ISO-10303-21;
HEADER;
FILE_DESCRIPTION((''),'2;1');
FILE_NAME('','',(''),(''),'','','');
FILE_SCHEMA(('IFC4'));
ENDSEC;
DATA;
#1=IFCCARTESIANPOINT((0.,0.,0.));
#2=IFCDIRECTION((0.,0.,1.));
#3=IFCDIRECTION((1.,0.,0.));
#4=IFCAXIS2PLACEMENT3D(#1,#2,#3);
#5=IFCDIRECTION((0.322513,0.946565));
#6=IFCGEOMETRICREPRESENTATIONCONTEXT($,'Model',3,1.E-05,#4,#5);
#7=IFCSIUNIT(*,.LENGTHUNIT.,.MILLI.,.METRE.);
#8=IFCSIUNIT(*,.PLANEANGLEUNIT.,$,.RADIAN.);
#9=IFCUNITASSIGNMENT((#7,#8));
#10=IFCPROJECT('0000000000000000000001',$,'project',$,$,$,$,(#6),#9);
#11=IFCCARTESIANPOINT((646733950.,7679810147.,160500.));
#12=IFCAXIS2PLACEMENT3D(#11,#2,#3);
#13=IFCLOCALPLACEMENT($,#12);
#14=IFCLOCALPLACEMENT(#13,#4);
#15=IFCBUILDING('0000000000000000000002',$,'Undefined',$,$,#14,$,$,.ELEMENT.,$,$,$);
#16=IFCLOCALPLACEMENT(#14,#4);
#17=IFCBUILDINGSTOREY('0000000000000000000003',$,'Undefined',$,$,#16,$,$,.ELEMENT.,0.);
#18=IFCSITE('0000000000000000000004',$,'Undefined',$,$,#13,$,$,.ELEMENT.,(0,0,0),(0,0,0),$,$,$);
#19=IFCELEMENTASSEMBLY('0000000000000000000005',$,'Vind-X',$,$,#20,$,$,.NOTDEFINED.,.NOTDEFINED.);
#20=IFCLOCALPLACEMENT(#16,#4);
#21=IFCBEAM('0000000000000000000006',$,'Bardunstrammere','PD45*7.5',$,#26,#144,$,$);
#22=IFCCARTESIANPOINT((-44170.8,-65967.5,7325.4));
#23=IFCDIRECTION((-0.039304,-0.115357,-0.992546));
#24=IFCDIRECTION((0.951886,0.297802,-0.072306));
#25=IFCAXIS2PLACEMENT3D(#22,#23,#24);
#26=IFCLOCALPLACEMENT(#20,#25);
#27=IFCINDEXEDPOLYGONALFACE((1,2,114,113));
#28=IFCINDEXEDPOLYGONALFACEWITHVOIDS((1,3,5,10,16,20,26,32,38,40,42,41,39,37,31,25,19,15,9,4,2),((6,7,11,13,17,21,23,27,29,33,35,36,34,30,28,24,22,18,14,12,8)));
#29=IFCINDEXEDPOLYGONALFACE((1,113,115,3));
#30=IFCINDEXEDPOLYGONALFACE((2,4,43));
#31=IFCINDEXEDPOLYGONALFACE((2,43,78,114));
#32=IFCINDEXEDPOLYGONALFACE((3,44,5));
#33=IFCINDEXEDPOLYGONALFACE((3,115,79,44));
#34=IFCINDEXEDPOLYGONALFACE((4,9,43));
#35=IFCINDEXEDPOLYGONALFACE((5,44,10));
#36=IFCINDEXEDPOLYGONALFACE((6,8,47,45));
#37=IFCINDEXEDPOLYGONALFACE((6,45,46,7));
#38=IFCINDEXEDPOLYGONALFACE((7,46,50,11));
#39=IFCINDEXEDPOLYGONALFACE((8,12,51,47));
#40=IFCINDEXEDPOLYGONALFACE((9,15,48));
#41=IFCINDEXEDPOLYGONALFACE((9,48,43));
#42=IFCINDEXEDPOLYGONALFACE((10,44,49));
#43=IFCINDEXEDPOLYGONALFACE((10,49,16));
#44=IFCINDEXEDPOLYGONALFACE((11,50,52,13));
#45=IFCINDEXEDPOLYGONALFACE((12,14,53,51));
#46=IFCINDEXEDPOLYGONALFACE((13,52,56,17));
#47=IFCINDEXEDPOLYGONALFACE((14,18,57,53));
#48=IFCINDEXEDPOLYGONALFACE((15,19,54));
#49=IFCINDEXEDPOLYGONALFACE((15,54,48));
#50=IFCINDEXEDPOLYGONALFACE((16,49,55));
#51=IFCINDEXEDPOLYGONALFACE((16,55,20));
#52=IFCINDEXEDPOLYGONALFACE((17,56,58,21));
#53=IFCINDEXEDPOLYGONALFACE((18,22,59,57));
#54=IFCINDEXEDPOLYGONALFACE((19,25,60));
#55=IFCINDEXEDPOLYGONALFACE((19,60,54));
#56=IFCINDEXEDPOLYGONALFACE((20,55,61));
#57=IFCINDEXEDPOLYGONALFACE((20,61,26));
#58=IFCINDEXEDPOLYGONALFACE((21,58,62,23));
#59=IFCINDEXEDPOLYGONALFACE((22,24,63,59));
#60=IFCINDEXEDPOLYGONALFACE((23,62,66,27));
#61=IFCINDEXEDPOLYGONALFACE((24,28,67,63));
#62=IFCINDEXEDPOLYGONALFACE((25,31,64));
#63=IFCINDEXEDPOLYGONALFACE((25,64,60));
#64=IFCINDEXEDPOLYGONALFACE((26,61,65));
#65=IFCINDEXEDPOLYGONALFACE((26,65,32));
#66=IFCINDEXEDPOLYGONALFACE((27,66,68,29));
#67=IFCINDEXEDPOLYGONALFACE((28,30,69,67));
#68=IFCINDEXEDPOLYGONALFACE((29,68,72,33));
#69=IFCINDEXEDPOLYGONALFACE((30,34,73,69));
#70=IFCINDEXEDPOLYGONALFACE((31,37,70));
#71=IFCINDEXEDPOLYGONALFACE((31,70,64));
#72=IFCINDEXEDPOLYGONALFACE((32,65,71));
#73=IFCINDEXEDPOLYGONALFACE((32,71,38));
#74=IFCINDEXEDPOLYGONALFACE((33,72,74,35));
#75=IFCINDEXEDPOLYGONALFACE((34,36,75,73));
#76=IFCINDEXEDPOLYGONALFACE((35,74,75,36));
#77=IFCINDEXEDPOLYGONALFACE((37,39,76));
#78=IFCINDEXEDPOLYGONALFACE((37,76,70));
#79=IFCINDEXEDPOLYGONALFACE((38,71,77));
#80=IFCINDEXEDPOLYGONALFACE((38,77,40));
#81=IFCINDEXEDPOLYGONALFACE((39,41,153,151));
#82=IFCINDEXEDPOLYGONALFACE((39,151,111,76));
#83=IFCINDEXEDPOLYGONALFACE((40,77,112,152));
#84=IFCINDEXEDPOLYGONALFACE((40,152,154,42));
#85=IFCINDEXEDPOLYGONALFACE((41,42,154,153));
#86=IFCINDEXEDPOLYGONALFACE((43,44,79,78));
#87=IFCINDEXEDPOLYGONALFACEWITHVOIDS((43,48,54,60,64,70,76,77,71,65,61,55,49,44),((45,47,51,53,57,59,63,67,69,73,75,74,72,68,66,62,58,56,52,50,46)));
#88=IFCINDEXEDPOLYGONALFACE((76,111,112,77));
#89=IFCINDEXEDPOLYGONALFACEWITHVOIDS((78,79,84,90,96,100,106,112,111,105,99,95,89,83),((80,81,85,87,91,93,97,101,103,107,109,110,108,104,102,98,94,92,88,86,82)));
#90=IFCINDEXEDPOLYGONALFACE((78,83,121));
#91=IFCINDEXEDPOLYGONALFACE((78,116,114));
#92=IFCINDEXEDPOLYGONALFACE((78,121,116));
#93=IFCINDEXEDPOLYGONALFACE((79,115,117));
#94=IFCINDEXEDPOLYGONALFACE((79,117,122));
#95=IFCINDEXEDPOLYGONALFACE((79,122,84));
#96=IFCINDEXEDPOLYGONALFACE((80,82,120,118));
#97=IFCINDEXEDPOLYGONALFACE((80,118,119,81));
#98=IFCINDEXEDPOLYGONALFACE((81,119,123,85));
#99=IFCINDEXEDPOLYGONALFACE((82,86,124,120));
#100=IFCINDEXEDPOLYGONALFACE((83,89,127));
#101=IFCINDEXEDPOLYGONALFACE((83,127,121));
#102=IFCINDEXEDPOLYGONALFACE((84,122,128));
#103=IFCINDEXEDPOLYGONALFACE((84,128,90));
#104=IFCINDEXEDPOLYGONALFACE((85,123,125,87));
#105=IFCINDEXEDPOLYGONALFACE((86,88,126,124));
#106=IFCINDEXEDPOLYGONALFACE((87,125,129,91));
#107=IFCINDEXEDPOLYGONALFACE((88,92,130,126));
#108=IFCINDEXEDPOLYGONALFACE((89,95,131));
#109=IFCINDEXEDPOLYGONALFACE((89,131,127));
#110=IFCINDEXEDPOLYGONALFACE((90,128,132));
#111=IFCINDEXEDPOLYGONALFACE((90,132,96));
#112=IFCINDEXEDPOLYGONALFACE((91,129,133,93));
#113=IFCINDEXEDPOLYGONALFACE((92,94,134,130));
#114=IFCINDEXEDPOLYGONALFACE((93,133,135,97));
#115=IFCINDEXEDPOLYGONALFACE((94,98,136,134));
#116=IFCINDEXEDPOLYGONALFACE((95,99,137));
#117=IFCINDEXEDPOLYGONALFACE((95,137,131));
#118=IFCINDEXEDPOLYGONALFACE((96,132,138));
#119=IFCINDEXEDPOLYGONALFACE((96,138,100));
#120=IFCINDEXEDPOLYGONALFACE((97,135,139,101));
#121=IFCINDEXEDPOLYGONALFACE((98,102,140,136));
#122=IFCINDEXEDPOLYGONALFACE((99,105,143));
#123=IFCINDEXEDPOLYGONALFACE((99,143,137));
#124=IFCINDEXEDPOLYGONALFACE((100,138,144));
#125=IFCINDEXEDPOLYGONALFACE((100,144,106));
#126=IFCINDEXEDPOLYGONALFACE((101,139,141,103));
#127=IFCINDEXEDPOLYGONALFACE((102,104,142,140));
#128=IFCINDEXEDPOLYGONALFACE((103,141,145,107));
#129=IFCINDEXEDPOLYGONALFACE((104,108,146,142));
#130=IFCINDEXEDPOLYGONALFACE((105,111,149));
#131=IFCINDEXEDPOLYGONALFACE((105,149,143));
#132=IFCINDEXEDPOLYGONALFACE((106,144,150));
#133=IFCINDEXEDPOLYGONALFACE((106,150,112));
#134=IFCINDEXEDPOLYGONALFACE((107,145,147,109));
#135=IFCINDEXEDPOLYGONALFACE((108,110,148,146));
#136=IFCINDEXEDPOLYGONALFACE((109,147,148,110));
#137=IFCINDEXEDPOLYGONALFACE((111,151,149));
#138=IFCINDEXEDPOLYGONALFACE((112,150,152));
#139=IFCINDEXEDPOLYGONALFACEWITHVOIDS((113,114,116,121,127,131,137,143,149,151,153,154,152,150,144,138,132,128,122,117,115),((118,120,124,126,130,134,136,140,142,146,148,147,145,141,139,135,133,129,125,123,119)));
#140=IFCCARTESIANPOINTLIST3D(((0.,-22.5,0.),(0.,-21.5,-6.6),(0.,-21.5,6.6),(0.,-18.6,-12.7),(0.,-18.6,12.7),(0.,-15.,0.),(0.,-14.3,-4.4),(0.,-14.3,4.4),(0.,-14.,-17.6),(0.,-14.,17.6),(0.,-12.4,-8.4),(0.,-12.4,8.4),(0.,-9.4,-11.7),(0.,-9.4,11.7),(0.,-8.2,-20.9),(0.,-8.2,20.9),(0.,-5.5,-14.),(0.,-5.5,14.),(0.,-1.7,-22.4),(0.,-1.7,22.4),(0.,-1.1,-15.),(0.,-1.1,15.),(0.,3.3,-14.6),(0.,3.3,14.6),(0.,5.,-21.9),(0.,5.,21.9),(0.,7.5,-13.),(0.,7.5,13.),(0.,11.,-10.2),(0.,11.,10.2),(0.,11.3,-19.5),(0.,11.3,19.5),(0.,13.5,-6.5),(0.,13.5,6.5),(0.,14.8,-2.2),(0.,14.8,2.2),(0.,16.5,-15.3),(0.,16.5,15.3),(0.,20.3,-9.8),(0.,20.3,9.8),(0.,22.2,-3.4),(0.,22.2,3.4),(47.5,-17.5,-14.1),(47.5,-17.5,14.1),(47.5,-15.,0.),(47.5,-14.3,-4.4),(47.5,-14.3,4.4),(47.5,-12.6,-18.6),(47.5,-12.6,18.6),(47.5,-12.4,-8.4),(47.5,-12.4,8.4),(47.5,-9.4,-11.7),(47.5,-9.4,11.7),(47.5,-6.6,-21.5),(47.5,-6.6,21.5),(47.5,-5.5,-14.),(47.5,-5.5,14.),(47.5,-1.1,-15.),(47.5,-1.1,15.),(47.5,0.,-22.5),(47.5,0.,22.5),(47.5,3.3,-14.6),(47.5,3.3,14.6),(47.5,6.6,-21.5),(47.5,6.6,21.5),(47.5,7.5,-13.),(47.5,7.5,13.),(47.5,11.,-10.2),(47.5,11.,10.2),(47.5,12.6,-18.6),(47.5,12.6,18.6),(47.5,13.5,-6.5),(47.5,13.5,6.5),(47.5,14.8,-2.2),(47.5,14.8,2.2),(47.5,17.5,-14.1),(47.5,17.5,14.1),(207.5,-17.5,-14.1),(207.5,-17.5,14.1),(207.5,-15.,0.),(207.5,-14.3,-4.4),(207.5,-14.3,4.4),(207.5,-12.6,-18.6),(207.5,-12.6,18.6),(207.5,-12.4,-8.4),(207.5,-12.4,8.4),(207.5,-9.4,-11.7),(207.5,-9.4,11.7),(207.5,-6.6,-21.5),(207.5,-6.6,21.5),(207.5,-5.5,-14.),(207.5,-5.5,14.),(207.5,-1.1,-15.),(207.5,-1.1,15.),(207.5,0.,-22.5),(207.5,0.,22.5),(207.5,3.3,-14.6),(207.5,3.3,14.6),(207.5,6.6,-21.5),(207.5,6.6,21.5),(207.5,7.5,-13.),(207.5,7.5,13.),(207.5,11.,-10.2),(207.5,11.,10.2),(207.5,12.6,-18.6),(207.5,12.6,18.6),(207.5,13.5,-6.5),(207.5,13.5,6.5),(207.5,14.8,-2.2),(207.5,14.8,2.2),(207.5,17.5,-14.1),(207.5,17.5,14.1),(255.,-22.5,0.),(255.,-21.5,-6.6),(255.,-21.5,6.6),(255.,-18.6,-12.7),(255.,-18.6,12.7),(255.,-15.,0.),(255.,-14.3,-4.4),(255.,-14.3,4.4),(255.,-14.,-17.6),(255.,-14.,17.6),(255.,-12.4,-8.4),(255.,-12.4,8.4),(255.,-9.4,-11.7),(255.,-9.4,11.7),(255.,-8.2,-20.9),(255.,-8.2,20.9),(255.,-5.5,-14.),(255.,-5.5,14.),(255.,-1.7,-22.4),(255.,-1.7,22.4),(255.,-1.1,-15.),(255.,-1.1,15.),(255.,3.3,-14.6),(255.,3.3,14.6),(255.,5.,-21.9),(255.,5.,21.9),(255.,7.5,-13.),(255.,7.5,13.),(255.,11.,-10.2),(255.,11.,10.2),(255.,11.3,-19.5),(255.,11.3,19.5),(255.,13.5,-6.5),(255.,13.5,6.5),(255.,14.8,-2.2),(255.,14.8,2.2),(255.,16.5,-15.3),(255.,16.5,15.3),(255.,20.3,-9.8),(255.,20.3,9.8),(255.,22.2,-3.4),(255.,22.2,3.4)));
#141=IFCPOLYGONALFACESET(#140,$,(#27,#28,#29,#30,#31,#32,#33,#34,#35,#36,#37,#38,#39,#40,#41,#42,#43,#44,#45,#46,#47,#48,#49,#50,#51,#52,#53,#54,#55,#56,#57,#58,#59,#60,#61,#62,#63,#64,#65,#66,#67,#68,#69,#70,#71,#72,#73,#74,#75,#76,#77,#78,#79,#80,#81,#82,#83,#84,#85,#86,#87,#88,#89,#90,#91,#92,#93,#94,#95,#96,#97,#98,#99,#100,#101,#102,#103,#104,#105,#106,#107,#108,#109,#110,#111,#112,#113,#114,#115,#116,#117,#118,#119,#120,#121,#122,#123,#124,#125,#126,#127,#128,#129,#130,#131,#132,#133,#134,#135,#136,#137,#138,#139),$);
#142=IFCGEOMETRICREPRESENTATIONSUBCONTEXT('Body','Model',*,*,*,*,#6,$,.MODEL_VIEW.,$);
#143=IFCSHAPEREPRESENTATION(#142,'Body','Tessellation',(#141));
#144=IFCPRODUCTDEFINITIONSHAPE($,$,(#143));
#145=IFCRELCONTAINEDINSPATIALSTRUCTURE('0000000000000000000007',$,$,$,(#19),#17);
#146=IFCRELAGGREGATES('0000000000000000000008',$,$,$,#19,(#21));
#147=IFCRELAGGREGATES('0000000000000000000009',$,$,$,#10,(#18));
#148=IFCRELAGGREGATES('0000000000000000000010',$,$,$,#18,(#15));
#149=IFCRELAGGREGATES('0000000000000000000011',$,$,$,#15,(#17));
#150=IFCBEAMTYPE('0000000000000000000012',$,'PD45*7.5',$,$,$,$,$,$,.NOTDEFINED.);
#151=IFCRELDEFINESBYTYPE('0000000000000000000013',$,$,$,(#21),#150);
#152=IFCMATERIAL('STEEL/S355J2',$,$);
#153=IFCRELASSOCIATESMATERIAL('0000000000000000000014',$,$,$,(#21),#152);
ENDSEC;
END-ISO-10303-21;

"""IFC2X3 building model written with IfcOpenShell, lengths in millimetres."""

from ifc_helpers import new_model, si_unit, direction, frame, origin_with_axes, origin_2d_with_axis, place, context, subcontext, project, spatial, rectangle, hollow_circle, extrude, boolean, material, type_object, element, aggregate, save


model = new_model("IFC2X3")

# Units and contexts
model_context = context("Model", 3, precision=1e-05, world=origin_with_axes(), true_north=direction((0.322513, 0.946565)))
body_context = subcontext(model_context, "Body", "Model", "MODEL_VIEW")
ifc_project = project(units=[si_unit("LENGTHUNIT", "METRE", prefix="MILLI"), si_unit("PLANEANGLEUNIT", "RADIAN")], contexts=[model_context])

# Site, building, storey
site_placement = place(None, frame((646733950.0, 7679810147.0, 160500.0), z_axis=(0.0, 0.0, 1.0), x_axis=(1.0, 0.0, 0.0)))
site = spatial("IfcSite", under=ifc_project, at=site_placement, Name="Undefined", CompositionType="ELEMENT", RefLatitude=(0, 0, 0), RefLongitude=(0, 0, 0))
building_placement = place(site_placement, origin_with_axes())
building = spatial("IfcBuilding", under=site, at=building_placement, Name="Undefined", CompositionType="ELEMENT")
storey_placement = place(building_placement, origin_with_axes())
storey = spatial("IfcBuildingStorey", under=building, at=storey_placement, Name="Undefined", CompositionType="ELEMENT", Elevation=0.0)

# Element assembly, beam
assembly_1_placement = place(storey_placement, origin_with_axes())
assembly_1 = element("IfcElementAssembly", 1, at=assembly_1_placement, inside=storey, Name="Vind-X", AssemblyPlace="NOTDEFINED", PredefinedType="NOTDEFINED")
ifc_material_1 = material(Name="STEEL/S355J2")
beam_type_1 = type_object("IfcBeamType", Name="PD45*7.5", PredefinedType="NOTDEFINED")
beam_1_placement = place(assembly_1_placement, frame((-44170.8, -65967.5, 7325.4), z_axis=(-0.039304, -0.115357, -0.992546), x_axis=(0.951886, 0.297802, -0.072306)))
beam_1 = element("IfcBeam", 2, at=beam_1_placement, type_object=beam_type_1, material=ifc_material_1, Name="Bardunstrammere", Description="PD45*7.5", context=body_context, shape_type="CSG", body=[
    boolean("DIFFERENCE", extrude(hollow_circle(Radius=22.5, WallThickness=7.5, at=origin_2d_with_axis()), frame((255.0, 0.0, 0.0), z_axis=(-1.0, 0.0, 0.0), x_axis=(0.0, -1.0, 0.0)), (0.0, 0.0, 1.0), 255.0), extrude(rectangle(XDim=35.0, YDim=90.0, at=origin_2d_with_axis()), frame((207.5, 0.0, 0.0), z_axis=(-1.0, 0.0, 0.0), x_axis=(0.0, -1.0, 0.0)), (0.0, 0.0, 1.0), 160.0)),
])

aggregate(assembly_1, [beam_1])

save(model, "model.ifc")
